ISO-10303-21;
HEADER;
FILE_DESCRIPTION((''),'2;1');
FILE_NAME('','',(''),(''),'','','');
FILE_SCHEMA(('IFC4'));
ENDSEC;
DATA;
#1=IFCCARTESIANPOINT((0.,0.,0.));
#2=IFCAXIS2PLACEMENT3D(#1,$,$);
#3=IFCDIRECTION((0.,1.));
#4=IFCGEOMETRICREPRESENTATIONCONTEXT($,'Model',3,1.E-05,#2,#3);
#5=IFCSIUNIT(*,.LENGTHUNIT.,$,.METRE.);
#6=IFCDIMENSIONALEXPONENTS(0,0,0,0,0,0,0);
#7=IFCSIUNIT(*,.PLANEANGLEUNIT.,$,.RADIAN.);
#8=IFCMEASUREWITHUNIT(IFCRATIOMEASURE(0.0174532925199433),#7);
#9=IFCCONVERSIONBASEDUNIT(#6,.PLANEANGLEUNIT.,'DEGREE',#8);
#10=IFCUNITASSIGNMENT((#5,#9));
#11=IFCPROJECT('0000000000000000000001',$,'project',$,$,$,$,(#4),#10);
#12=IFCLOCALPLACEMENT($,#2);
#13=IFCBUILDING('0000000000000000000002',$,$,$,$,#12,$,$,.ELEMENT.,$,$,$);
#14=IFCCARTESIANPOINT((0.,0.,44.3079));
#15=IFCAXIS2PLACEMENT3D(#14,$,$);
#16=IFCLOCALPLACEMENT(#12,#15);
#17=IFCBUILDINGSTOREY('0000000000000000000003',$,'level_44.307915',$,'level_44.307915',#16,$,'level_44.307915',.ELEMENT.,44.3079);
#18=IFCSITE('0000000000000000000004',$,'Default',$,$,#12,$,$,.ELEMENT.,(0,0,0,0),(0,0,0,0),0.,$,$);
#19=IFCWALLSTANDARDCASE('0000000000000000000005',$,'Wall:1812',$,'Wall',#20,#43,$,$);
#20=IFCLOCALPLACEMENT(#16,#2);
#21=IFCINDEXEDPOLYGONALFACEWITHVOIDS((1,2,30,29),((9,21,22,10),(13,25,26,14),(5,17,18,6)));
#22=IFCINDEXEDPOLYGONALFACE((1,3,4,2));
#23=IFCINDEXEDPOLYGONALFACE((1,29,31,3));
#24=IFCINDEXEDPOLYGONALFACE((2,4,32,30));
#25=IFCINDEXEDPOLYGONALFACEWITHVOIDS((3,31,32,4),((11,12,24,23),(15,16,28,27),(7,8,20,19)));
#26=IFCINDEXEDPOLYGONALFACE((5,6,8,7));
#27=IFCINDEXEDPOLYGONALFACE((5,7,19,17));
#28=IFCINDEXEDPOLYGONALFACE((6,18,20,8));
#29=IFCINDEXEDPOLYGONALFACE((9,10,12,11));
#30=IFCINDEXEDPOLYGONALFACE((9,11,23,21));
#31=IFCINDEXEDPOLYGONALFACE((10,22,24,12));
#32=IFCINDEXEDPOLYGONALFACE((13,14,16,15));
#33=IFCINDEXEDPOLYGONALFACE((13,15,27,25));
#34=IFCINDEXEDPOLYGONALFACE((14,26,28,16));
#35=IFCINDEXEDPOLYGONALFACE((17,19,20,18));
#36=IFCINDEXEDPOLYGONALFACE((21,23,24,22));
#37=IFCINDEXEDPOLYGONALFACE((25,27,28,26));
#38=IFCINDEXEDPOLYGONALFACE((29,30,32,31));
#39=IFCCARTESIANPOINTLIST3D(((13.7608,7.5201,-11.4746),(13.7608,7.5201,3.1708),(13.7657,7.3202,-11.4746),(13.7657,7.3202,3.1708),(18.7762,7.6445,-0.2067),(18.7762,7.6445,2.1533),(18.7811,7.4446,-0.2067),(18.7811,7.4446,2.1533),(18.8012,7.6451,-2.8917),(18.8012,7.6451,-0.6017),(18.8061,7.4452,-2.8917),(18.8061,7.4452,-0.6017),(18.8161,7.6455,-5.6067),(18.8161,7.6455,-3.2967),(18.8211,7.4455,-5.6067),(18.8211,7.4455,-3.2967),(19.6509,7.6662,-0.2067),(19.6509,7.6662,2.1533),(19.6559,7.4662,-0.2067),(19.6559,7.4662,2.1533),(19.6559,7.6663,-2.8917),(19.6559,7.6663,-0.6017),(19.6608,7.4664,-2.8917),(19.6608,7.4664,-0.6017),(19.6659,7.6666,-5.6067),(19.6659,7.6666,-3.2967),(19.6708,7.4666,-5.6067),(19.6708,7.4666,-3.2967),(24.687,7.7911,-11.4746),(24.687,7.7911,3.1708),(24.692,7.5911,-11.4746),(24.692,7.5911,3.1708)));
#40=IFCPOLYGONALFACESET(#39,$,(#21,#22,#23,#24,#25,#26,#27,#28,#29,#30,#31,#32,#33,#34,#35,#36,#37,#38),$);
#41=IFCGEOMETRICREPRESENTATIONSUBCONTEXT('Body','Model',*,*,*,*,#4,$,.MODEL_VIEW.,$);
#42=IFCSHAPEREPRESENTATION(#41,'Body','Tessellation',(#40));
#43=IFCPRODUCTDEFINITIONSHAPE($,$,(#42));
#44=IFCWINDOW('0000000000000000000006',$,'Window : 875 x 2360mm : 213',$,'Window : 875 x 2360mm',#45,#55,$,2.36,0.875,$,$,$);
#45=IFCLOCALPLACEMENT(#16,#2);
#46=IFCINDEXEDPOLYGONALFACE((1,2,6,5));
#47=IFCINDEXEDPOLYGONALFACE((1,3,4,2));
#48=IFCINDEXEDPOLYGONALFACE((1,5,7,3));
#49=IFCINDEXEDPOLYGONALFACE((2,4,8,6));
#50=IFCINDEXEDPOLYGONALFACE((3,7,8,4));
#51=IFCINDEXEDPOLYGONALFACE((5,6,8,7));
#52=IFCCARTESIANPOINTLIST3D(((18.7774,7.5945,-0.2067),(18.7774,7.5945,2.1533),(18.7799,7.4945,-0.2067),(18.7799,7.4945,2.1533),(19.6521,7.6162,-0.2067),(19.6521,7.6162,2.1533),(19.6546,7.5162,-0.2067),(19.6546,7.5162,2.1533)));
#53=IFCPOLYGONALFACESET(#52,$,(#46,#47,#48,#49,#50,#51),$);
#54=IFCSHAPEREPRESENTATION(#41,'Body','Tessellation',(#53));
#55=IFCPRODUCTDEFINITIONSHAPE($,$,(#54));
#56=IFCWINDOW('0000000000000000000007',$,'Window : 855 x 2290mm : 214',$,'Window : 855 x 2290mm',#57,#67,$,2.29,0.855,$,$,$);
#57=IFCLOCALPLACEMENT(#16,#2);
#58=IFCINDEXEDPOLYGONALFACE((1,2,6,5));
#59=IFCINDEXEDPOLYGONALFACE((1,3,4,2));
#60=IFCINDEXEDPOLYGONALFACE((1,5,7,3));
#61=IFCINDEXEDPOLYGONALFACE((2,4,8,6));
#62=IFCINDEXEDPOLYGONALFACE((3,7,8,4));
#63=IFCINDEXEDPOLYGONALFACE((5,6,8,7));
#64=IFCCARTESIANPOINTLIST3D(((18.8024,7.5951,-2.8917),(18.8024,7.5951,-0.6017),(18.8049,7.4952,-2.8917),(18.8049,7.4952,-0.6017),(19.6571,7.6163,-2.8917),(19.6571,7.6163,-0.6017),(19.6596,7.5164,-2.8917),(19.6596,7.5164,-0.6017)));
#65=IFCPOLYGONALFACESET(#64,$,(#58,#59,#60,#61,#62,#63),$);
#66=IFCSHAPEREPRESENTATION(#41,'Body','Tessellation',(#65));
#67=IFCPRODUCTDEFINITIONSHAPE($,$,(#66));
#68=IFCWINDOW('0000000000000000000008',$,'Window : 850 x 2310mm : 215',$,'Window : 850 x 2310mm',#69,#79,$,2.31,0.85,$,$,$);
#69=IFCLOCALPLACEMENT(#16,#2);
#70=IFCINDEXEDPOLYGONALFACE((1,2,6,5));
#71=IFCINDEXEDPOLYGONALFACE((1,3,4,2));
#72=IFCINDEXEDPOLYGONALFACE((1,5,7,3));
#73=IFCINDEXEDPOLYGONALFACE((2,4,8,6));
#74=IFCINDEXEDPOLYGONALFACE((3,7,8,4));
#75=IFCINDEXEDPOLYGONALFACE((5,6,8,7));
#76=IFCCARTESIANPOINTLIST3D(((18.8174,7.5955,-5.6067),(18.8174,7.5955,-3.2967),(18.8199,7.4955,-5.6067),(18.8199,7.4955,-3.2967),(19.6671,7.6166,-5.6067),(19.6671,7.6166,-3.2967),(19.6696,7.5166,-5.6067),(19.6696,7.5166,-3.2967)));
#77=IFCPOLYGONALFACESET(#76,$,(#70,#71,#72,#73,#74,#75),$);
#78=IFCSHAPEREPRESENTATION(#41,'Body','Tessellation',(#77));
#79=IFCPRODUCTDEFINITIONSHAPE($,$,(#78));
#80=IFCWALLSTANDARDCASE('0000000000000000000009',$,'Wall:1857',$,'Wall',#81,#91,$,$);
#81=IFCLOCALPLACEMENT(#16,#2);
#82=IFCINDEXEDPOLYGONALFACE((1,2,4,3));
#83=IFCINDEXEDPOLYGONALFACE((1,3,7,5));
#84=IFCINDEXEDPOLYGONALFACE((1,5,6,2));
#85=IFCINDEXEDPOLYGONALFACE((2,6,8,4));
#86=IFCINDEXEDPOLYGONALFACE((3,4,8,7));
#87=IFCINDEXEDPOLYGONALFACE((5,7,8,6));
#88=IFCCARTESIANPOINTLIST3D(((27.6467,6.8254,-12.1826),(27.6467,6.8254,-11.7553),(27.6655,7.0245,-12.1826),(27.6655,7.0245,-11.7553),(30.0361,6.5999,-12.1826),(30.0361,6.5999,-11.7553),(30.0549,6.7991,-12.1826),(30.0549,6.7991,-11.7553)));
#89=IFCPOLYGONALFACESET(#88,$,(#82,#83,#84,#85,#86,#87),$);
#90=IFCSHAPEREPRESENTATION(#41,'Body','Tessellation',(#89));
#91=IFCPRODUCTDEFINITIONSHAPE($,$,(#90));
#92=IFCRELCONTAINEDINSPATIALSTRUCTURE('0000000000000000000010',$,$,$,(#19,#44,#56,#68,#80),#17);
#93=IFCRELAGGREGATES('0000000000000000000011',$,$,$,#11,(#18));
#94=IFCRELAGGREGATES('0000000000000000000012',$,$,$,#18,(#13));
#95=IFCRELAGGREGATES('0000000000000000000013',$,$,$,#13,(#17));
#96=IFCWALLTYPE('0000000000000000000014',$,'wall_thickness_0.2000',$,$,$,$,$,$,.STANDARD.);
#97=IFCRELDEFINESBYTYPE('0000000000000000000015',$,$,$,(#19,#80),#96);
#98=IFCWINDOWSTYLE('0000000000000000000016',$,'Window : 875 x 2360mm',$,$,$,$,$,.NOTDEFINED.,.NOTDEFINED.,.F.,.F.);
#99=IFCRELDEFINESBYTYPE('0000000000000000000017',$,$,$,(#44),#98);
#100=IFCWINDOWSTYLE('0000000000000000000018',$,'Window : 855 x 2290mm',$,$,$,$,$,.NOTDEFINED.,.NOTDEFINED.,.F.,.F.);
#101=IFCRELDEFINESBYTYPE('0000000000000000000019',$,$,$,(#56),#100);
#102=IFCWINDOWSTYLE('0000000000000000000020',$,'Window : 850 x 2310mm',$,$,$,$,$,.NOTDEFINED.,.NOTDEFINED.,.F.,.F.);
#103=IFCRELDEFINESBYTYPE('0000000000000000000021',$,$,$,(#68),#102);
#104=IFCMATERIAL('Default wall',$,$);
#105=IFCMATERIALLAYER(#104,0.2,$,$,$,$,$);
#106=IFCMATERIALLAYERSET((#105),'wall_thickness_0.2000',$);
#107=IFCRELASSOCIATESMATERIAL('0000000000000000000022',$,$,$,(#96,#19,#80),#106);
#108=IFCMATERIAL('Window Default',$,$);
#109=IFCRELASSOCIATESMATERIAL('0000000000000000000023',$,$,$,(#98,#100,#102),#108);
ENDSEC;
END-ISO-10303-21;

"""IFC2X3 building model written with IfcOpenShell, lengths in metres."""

from ifc_helpers import new_model, entity, si_unit, converted_unit, direction, frame, frame_2d, origin, origin_2d_with_axis, place, context, subcontext, project, spatial, polyline, rectangle, outline, extrude, source, transform, mapped, material, layer, layer_set, layer_usage, type_object, type_shapes, element, fill, save


model = new_model("IFC2X3")

# Units and contexts
model_context = context("Model", 3, precision=1e-05, world=origin(), true_north=direction((0.0, 1.0)))
body_context = subcontext(model_context, "Body", "Model", "MODEL_VIEW")
ifc_project = project(units=[si_unit("LENGTHUNIT", "METRE"), converted_unit("PLANEANGLEUNIT", "DEGREE", entity("IfcRatioMeasure", 0.0174532925199433), si_unit("PLANEANGLEUNIT", "RADIAN"), dimensions=[0, 0, 0, 0, 0, 0, 0])], contexts=[model_context])

# Site, building, storey
placement_1 = place(None, origin())
site = spatial("IfcSite", under=ifc_project, at=placement_1, Name="Default", CompositionType="ELEMENT", RefLatitude=(0, 0, 0, 0), RefLongitude=(0, 0, 0, 0), RefElevation=0.0)
building = spatial("IfcBuilding", under=site, at=placement_1, CompositionType="ELEMENT")
storey_placement = place(placement_1, frame((0.0, 0.0, 44.3079)))
storey = spatial("IfcBuildingStorey", under=building, at=storey_placement, Name="level_44.307915", ObjectType="level_44.307915", LongName="level_44.307915", CompositionType="ELEMENT", Elevation=44.3079)

# Shared definitions
ifc_material_1 = material(Name="Default wall")
ifc_layer = layer(ifc_material_1, 0.2)
ifc_layer_set = layer_set([ifc_layer], Name="wall_thickness_0.2000")
ifc_layer_usage = layer_usage(ifc_layer_set, "AXIS2", "POSITIVE", -0.1)
wall_type = type_object("IfcWallType", Name="wall_thickness_0.2000", PredefinedType="STANDARD", material=ifc_layer_set)

# Wall, openings, windows
placement_2 = place(placement_1, frame((0.0, 0.0, 32.8333)))
wall_1_placement = place(placement_2, frame((24.6895, 7.6911, 0.0), z_axis=(0.0, 0.0, 1.0), x_axis=(-0.999693, -0.024794, 0.0)))
wall_1 = element("IfcWallStandardCase", 1, at=wall_1_placement, inside=storey, type_object=wall_type, material=ifc_layer_usage, Name="Wall:1812", ObjectType="Wall", context=body_context, shape_type="SweptSolid", body=[
    extrude(outline(polyline([(10.9296, -0.1), (10.9296, 0.1), (0.0, 0.1), (0.0, -0.1), (10.9296, -0.1)])), origin(), (0.0, 0.0, 1.0), 14.6454),
])
opening_1_placement = place(wall_1_placement, frame((5.0377, -0.1, 11.2679)))
opening_1 = element("IfcOpeningElement", 2, at=opening_1_placement, cuts=wall_1, ObjectType="Opening", context=body_context, shape_type="SweptSolid", body=[
    extrude(rectangle(XDim=0.875, YDim=2.36, at=frame_2d((1.18, 0.4375), x_axis=(0.0, 1.0))), frame((0.0, 0.0, 0.0), z_axis=(0.0, 1.0, 0.0), x_axis=(0.0, 0.0, 1.0)), (0.0, 0.0, 1.0), 0.2),
])
opening_2_placement = place(wall_1_placement, frame((5.0327, -0.1, 8.5829)))
opening_2 = element("IfcOpeningElement", 3, at=opening_2_placement, cuts=wall_1, ObjectType="Opening", context=body_context, shape_type="SweptSolid", body=[
    extrude(rectangle(XDim=0.855, YDim=2.29, at=frame_2d((1.145, 0.4275), x_axis=(0.0, 1.0))), frame((0.0, 0.0, 0.0), z_axis=(0.0, 1.0, 0.0), x_axis=(0.0, 0.0, 1.0)), (0.0, 0.0, 1.0), 0.2),
])
opening_3_placement = place(wall_1_placement, frame((5.0227, -0.1, 5.8679)))
opening_3 = element("IfcOpeningElement", 4, at=opening_3_placement, cuts=wall_1, ObjectType="Opening", context=body_context, shape_type="SweptSolid", body=[
    extrude(rectangle(XDim=0.85, YDim=2.31, at=frame_2d((1.155, 0.425), x_axis=(0.0, 1.0))), frame((0.0, 0.0, 0.0), z_axis=(0.0, 1.0, 0.0), x_axis=(0.0, 0.0, 1.0)), (0.0, 0.0, 1.0), 0.2),
])
ifc_material_2 = material(Name="Window Default")
window_style_1 = type_object("IfcWindowStyle", Name="Window : 875 x 2360mm", ConstructionType="NOTDEFINED", OperationType="NOTDEFINED", ParameterTakesPrecedence=False, Sizeable=False, material=ifc_material_2)
shared_shape_1 = source(origin(), body_context, "Body", "SweptSolid", [
    extrude(rectangle(XDim=0.1, YDim=0.875, at=origin_2d_with_axis()), frame((0.4375, 0.1, 0.0), z_axis=(0.0, 0.0, 1.0), x_axis=(0.0, 1.0, 0.0)), (0.0, 0.0, 1.0), 2.36),
])
type_shapes(window_style_1, [shared_shape_1])
window_1_placement = place(opening_1_placement, origin())
window_1 = element("IfcWindow", 5, at=window_1_placement, inside=storey, type_object=window_style_1, Name="Window : 875 x 2360mm : 213", ObjectType="Window : 875 x 2360mm", OverallHeight=2.36, OverallWidth=0.875, context=body_context, shape_type="MappedRepresentation", body=[
    mapped(shared_shape_1, transform((0.0, 0.0, 0.0), scale=1.0)),
])
fill(opening_1, window_1)
window_style_2 = type_object("IfcWindowStyle", Name="Window : 855 x 2290mm", ConstructionType="NOTDEFINED", OperationType="NOTDEFINED", ParameterTakesPrecedence=False, Sizeable=False, material=ifc_material_2)
shared_shape_2 = source(origin(), body_context, "Body", "SweptSolid", [
    extrude(rectangle(XDim=0.1, YDim=0.855, at=origin_2d_with_axis()), frame((0.4275, 0.1, 0.0), z_axis=(0.0, 0.0, 1.0), x_axis=(0.0, 1.0, 0.0)), (0.0, 0.0, 1.0), 2.29),
])
type_shapes(window_style_2, [shared_shape_2])
window_2_placement = place(opening_2_placement, origin())
window_2 = element("IfcWindow", 6, at=window_2_placement, inside=storey, type_object=window_style_2, Name="Window : 855 x 2290mm : 214", ObjectType="Window : 855 x 2290mm", OverallHeight=2.29, OverallWidth=0.855, context=body_context, shape_type="MappedRepresentation", body=[
    mapped(shared_shape_2, transform((0.0, 0.0, 0.0), scale=1.0)),
])
fill(opening_2, window_2)
window_style_3 = type_object("IfcWindowStyle", Name="Window : 850 x 2310mm", ConstructionType="NOTDEFINED", OperationType="NOTDEFINED", ParameterTakesPrecedence=False, Sizeable=False, material=ifc_material_2)
shared_shape_3 = source(origin(), body_context, "Body", "SweptSolid", [
    extrude(rectangle(XDim=0.1, YDim=0.85, at=origin_2d_with_axis()), frame((0.425, 0.1, 0.0), z_axis=(0.0, 0.0, 1.0), x_axis=(0.0, 1.0, 0.0)), (0.0, 0.0, 1.0), 2.31),
])
type_shapes(window_style_3, [shared_shape_3])
window_3_placement = place(opening_3_placement, origin())
window_3 = element("IfcWindow", 7, at=window_3_placement, inside=storey, type_object=window_style_3, Name="Window : 850 x 2310mm : 215", ObjectType="Window : 850 x 2310mm", OverallHeight=2.31, OverallWidth=0.85, context=body_context, shape_type="MappedRepresentation", body=[
    mapped(shared_shape_3, transform((0.0, 0.0, 0.0), scale=1.0)),
])
fill(opening_3, window_3)

# Wall
placement_3 = place(placement_1, frame((0.0, 0.0, 32.1253)))
wall_2_placement = place(placement_3, frame((27.6561, 6.925, 0.0), z_axis=(0.0, 0.0, 1.0), x_axis=(0.995577, -0.093954, 0.0)))
element("IfcWallStandardCase", 8, at=wall_2_placement, inside=storey, type_object=wall_type, material=ifc_layer_usage, Name="Wall:1857", ObjectType="Wall", context=body_context, shape_type="SweptSolid", body=[
    extrude(outline(polyline([(2.4, -0.1), (2.4, 0.1), (0.0, 0.1), (0.0, -0.1), (2.4, -0.1)])), origin(), (0.0, 0.0, 1.0), 0.4273),
])

save(model, "model.ifc")
